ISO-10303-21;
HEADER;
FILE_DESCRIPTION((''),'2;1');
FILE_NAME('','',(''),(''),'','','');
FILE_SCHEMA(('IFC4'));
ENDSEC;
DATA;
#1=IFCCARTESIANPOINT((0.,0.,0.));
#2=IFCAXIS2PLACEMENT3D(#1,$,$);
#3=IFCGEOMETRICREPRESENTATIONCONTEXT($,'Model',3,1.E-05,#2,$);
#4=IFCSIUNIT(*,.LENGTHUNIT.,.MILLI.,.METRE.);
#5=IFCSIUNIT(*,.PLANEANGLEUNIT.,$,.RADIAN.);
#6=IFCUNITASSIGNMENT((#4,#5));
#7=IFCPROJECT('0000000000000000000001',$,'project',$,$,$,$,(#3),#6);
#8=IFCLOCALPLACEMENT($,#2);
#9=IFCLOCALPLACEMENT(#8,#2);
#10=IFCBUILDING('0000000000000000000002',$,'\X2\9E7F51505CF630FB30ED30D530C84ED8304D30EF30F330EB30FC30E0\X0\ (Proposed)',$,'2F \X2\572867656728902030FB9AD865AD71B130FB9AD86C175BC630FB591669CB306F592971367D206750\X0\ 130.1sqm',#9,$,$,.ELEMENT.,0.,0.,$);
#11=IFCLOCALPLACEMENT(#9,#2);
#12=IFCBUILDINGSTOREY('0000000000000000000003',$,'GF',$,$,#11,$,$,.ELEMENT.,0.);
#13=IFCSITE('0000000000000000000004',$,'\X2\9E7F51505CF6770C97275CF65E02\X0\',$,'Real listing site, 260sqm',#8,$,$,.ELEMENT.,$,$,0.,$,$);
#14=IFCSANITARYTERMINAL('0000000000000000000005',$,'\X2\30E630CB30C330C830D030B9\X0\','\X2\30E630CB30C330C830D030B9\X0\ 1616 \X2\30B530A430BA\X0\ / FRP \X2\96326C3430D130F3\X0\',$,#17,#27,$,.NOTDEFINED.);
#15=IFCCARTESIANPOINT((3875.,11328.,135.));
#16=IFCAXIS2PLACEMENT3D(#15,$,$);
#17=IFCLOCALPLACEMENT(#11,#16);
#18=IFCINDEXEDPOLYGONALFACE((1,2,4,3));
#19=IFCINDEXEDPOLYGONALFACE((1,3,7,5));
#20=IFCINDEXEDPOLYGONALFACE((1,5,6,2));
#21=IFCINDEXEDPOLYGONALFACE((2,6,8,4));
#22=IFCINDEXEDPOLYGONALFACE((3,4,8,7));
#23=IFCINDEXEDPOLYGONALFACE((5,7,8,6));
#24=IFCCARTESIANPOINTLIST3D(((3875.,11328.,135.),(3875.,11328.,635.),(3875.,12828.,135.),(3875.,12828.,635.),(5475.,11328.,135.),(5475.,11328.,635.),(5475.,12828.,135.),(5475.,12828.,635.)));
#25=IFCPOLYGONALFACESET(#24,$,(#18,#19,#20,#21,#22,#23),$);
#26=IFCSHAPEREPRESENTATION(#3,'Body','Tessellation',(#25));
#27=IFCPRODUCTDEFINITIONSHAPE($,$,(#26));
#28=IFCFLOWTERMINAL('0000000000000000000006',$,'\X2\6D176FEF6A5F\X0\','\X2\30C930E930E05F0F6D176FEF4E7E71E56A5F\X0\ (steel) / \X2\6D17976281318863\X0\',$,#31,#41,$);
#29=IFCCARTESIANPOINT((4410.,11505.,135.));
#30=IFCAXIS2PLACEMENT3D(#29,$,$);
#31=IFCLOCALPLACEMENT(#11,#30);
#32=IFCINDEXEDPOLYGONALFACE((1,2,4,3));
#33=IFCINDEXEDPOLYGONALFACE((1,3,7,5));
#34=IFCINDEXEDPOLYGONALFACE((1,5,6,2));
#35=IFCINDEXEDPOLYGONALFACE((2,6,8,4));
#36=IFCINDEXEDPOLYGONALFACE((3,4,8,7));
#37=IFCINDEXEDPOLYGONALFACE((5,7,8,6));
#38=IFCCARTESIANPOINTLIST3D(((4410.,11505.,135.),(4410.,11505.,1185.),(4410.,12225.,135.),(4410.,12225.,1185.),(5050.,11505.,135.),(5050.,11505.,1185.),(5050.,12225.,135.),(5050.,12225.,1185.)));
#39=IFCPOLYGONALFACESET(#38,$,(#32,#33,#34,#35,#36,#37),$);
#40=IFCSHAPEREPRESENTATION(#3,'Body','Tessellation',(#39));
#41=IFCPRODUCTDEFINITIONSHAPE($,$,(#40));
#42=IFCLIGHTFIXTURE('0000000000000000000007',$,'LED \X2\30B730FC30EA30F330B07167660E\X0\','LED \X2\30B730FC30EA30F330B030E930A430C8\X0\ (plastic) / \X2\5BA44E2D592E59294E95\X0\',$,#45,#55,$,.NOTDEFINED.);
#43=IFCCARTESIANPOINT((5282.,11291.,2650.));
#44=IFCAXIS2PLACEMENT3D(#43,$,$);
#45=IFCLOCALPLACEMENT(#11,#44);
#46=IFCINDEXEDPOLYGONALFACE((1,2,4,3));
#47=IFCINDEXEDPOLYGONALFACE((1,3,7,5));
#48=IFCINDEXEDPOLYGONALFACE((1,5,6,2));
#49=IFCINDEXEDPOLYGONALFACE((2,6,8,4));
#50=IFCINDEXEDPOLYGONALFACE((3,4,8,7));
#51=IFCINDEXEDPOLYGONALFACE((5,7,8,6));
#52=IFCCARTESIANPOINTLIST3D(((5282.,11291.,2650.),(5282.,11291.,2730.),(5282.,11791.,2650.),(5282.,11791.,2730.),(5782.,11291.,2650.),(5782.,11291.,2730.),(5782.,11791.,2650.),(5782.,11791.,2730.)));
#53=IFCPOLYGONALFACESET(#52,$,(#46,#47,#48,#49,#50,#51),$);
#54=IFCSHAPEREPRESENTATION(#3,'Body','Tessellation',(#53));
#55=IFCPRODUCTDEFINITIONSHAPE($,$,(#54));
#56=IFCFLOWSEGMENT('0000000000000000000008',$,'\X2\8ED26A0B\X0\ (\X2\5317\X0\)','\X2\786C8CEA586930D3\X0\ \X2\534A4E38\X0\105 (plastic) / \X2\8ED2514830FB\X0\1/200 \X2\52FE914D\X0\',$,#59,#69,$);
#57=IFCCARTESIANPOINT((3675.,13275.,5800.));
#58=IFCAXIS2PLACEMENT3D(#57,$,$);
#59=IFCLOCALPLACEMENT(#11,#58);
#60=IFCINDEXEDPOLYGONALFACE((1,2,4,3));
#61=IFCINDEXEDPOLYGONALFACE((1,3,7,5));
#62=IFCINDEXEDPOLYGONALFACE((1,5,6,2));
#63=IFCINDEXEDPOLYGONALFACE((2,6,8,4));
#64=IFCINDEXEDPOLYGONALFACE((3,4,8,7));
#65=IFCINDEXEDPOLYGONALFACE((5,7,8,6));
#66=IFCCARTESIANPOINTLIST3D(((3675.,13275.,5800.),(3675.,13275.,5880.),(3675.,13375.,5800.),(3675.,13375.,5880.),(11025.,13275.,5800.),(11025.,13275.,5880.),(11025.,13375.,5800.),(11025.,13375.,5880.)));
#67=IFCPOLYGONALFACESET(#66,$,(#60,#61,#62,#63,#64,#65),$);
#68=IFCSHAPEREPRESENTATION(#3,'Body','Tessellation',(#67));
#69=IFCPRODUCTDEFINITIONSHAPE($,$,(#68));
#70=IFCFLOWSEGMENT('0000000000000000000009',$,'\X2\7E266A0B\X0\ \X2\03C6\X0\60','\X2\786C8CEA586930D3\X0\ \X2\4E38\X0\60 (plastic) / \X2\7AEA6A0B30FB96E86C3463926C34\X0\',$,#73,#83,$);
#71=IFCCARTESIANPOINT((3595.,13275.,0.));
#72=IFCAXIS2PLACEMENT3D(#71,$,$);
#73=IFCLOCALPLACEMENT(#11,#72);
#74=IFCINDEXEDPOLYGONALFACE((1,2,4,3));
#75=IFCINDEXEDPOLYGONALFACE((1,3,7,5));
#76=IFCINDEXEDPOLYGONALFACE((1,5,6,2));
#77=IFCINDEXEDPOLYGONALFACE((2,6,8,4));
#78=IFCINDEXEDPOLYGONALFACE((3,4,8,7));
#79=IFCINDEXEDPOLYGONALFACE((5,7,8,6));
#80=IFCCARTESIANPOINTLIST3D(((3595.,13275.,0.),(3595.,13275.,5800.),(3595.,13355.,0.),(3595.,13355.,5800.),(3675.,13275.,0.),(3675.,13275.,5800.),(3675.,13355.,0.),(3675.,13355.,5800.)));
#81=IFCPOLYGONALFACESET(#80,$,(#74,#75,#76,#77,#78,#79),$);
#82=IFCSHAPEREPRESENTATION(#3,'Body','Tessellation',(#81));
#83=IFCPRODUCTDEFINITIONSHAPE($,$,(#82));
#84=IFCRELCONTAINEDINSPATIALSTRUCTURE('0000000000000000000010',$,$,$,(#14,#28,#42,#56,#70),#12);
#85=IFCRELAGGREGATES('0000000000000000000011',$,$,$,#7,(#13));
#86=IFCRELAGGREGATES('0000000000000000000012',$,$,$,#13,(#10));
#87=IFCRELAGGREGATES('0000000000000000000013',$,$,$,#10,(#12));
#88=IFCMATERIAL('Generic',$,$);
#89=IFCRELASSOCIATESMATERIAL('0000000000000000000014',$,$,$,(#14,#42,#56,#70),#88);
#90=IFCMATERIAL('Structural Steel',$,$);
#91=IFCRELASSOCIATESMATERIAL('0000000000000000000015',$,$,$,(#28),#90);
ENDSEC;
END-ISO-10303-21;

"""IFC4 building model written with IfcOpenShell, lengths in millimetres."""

from ifc_helpers import new_model, si_unit, frame, frame_2d, origin, place, context, project, spatial, rectangle, extrude, material, element, save


model = new_model("IFC4")

# Units and contexts
model_context = context("Model", 3, precision=1e-05, world=origin())
ifc_project = project(units=[si_unit("LENGTHUNIT", "METRE", prefix="MILLI"), si_unit("PLANEANGLEUNIT", "RADIAN")], contexts=[model_context])

# Site, building, storey
site_placement = place(None, origin())
site = spatial("IfcSite", under=ifc_project, at=site_placement, Name="鹿児島県霧島市", ObjectType="Real listing site, 260sqm", CompositionType="ELEMENT", RefElevation=0.0)
building_placement = place(site_placement, origin())
building = spatial("IfcBuilding", under=site, at=building_placement, Name="鹿児島・ロフト付きワンルーム (Proposed)", ObjectType="2F 在来木造・高断熱・高気密・外構は天然素材 130.1sqm", CompositionType="ELEMENT", ElevationOfRefHeight=0.0, ElevationOfTerrain=0.0)
storey_placement = place(building_placement, origin())
storey = spatial("IfcBuildingStorey", under=building, at=storey_placement, Name="GF", CompositionType="ELEMENT", Elevation=0.0)

# Sanitary terminal
ifc_material_1 = material(Name="Generic")
sanitary_terminal_placement = place(storey_placement, frame((3875.0, 11328.0, 135.0)))
element("IfcSanitaryTerminal", 1, at=sanitary_terminal_placement, inside=storey, material=ifc_material_1, Name="ユニットバス", Description="ユニットバス 1616 サイズ / FRP 防水パン", PredefinedType="NOTDEFINED", context=model_context, shape_type="SweptSolid", body=[
    extrude(rectangle(XDim=1600.0, YDim=1500.0, at=frame_2d((800.0, 750.0))), frame((3875.0, 11328.0, 135.0)), (0.0, 0.0, 1.0), 500.0),
])

# Flow terminal
ifc_material_2 = material(Name="Structural Steel")
flow_terminal_placement = place(storey_placement, frame((4410.0, 11505.0, 135.0)))
element("IfcFlowTerminal", 2, at=flow_terminal_placement, inside=storey, material=ifc_material_2, Name="洗濯機", Description="ドラム式洗濯乾燥機 (steel) / 洗面脱衣", context=model_context, shape_type="SweptSolid", body=[
    extrude(rectangle(XDim=640.0, YDim=720.0, at=frame_2d((320.0, 360.0))), frame((4410.0, 11505.0, 135.0)), (0.0, 0.0, 1.0), 1050.0),
])

# Light fixture
light_fixture_placement = place(storey_placement, frame((5282.0, 11291.0, 2650.0)))
element("IfcLightFixture", 3, at=light_fixture_placement, inside=storey, material=ifc_material_1, Name="LED シーリング照明", Description="LED シーリングライト (plastic) / 室中央天井", PredefinedType="NOTDEFINED", context=model_context, shape_type="SweptSolid", body=[
    extrude(rectangle(XDim=500.0, YDim=500.0, at=frame_2d((250.0, 250.0))), frame((5282.0, 11291.0, 2650.0)), (0.0, 0.0, 1.0), 80.0),
])

# Flow segments
flow_segment_1_placement = place(storey_placement, frame((3675.0, 13275.0, 5800.0)))
element("IfcFlowSegment", 4, at=flow_segment_1_placement, inside=storey, material=ifc_material_1, Name="軒樋 (北)", Description="硬質塩ビ 半丸105 (plastic) / 軒先・1/200 勾配", context=model_context, shape_type="SweptSolid", body=[
    extrude(rectangle(XDim=7350.0, YDim=100.0, at=frame_2d((3675.0, 50.0))), frame((3675.0, 13275.0, 5800.0)), (0.0, 0.0, 1.0), 80.0),
])
flow_segment_2_placement = place(storey_placement, frame((3595.0, 13275.0, 0.0)))
element("IfcFlowSegment", 5, at=flow_segment_2_placement, inside=storey, material=ifc_material_1, Name="縦樋 φ60", Description="硬質塩ビ 丸60 (plastic) / 竪樋・雨水排水", context=model_context, shape_type="SweptSolid", body=[
    extrude(rectangle(XDim=80.0, YDim=80.0, at=frame_2d((40.0, 40.0))), frame((3595.0, 13275.0, 0.0)), (0.0, 0.0, 1.0), 5800.0),
])

save(model, "model.ifc")
